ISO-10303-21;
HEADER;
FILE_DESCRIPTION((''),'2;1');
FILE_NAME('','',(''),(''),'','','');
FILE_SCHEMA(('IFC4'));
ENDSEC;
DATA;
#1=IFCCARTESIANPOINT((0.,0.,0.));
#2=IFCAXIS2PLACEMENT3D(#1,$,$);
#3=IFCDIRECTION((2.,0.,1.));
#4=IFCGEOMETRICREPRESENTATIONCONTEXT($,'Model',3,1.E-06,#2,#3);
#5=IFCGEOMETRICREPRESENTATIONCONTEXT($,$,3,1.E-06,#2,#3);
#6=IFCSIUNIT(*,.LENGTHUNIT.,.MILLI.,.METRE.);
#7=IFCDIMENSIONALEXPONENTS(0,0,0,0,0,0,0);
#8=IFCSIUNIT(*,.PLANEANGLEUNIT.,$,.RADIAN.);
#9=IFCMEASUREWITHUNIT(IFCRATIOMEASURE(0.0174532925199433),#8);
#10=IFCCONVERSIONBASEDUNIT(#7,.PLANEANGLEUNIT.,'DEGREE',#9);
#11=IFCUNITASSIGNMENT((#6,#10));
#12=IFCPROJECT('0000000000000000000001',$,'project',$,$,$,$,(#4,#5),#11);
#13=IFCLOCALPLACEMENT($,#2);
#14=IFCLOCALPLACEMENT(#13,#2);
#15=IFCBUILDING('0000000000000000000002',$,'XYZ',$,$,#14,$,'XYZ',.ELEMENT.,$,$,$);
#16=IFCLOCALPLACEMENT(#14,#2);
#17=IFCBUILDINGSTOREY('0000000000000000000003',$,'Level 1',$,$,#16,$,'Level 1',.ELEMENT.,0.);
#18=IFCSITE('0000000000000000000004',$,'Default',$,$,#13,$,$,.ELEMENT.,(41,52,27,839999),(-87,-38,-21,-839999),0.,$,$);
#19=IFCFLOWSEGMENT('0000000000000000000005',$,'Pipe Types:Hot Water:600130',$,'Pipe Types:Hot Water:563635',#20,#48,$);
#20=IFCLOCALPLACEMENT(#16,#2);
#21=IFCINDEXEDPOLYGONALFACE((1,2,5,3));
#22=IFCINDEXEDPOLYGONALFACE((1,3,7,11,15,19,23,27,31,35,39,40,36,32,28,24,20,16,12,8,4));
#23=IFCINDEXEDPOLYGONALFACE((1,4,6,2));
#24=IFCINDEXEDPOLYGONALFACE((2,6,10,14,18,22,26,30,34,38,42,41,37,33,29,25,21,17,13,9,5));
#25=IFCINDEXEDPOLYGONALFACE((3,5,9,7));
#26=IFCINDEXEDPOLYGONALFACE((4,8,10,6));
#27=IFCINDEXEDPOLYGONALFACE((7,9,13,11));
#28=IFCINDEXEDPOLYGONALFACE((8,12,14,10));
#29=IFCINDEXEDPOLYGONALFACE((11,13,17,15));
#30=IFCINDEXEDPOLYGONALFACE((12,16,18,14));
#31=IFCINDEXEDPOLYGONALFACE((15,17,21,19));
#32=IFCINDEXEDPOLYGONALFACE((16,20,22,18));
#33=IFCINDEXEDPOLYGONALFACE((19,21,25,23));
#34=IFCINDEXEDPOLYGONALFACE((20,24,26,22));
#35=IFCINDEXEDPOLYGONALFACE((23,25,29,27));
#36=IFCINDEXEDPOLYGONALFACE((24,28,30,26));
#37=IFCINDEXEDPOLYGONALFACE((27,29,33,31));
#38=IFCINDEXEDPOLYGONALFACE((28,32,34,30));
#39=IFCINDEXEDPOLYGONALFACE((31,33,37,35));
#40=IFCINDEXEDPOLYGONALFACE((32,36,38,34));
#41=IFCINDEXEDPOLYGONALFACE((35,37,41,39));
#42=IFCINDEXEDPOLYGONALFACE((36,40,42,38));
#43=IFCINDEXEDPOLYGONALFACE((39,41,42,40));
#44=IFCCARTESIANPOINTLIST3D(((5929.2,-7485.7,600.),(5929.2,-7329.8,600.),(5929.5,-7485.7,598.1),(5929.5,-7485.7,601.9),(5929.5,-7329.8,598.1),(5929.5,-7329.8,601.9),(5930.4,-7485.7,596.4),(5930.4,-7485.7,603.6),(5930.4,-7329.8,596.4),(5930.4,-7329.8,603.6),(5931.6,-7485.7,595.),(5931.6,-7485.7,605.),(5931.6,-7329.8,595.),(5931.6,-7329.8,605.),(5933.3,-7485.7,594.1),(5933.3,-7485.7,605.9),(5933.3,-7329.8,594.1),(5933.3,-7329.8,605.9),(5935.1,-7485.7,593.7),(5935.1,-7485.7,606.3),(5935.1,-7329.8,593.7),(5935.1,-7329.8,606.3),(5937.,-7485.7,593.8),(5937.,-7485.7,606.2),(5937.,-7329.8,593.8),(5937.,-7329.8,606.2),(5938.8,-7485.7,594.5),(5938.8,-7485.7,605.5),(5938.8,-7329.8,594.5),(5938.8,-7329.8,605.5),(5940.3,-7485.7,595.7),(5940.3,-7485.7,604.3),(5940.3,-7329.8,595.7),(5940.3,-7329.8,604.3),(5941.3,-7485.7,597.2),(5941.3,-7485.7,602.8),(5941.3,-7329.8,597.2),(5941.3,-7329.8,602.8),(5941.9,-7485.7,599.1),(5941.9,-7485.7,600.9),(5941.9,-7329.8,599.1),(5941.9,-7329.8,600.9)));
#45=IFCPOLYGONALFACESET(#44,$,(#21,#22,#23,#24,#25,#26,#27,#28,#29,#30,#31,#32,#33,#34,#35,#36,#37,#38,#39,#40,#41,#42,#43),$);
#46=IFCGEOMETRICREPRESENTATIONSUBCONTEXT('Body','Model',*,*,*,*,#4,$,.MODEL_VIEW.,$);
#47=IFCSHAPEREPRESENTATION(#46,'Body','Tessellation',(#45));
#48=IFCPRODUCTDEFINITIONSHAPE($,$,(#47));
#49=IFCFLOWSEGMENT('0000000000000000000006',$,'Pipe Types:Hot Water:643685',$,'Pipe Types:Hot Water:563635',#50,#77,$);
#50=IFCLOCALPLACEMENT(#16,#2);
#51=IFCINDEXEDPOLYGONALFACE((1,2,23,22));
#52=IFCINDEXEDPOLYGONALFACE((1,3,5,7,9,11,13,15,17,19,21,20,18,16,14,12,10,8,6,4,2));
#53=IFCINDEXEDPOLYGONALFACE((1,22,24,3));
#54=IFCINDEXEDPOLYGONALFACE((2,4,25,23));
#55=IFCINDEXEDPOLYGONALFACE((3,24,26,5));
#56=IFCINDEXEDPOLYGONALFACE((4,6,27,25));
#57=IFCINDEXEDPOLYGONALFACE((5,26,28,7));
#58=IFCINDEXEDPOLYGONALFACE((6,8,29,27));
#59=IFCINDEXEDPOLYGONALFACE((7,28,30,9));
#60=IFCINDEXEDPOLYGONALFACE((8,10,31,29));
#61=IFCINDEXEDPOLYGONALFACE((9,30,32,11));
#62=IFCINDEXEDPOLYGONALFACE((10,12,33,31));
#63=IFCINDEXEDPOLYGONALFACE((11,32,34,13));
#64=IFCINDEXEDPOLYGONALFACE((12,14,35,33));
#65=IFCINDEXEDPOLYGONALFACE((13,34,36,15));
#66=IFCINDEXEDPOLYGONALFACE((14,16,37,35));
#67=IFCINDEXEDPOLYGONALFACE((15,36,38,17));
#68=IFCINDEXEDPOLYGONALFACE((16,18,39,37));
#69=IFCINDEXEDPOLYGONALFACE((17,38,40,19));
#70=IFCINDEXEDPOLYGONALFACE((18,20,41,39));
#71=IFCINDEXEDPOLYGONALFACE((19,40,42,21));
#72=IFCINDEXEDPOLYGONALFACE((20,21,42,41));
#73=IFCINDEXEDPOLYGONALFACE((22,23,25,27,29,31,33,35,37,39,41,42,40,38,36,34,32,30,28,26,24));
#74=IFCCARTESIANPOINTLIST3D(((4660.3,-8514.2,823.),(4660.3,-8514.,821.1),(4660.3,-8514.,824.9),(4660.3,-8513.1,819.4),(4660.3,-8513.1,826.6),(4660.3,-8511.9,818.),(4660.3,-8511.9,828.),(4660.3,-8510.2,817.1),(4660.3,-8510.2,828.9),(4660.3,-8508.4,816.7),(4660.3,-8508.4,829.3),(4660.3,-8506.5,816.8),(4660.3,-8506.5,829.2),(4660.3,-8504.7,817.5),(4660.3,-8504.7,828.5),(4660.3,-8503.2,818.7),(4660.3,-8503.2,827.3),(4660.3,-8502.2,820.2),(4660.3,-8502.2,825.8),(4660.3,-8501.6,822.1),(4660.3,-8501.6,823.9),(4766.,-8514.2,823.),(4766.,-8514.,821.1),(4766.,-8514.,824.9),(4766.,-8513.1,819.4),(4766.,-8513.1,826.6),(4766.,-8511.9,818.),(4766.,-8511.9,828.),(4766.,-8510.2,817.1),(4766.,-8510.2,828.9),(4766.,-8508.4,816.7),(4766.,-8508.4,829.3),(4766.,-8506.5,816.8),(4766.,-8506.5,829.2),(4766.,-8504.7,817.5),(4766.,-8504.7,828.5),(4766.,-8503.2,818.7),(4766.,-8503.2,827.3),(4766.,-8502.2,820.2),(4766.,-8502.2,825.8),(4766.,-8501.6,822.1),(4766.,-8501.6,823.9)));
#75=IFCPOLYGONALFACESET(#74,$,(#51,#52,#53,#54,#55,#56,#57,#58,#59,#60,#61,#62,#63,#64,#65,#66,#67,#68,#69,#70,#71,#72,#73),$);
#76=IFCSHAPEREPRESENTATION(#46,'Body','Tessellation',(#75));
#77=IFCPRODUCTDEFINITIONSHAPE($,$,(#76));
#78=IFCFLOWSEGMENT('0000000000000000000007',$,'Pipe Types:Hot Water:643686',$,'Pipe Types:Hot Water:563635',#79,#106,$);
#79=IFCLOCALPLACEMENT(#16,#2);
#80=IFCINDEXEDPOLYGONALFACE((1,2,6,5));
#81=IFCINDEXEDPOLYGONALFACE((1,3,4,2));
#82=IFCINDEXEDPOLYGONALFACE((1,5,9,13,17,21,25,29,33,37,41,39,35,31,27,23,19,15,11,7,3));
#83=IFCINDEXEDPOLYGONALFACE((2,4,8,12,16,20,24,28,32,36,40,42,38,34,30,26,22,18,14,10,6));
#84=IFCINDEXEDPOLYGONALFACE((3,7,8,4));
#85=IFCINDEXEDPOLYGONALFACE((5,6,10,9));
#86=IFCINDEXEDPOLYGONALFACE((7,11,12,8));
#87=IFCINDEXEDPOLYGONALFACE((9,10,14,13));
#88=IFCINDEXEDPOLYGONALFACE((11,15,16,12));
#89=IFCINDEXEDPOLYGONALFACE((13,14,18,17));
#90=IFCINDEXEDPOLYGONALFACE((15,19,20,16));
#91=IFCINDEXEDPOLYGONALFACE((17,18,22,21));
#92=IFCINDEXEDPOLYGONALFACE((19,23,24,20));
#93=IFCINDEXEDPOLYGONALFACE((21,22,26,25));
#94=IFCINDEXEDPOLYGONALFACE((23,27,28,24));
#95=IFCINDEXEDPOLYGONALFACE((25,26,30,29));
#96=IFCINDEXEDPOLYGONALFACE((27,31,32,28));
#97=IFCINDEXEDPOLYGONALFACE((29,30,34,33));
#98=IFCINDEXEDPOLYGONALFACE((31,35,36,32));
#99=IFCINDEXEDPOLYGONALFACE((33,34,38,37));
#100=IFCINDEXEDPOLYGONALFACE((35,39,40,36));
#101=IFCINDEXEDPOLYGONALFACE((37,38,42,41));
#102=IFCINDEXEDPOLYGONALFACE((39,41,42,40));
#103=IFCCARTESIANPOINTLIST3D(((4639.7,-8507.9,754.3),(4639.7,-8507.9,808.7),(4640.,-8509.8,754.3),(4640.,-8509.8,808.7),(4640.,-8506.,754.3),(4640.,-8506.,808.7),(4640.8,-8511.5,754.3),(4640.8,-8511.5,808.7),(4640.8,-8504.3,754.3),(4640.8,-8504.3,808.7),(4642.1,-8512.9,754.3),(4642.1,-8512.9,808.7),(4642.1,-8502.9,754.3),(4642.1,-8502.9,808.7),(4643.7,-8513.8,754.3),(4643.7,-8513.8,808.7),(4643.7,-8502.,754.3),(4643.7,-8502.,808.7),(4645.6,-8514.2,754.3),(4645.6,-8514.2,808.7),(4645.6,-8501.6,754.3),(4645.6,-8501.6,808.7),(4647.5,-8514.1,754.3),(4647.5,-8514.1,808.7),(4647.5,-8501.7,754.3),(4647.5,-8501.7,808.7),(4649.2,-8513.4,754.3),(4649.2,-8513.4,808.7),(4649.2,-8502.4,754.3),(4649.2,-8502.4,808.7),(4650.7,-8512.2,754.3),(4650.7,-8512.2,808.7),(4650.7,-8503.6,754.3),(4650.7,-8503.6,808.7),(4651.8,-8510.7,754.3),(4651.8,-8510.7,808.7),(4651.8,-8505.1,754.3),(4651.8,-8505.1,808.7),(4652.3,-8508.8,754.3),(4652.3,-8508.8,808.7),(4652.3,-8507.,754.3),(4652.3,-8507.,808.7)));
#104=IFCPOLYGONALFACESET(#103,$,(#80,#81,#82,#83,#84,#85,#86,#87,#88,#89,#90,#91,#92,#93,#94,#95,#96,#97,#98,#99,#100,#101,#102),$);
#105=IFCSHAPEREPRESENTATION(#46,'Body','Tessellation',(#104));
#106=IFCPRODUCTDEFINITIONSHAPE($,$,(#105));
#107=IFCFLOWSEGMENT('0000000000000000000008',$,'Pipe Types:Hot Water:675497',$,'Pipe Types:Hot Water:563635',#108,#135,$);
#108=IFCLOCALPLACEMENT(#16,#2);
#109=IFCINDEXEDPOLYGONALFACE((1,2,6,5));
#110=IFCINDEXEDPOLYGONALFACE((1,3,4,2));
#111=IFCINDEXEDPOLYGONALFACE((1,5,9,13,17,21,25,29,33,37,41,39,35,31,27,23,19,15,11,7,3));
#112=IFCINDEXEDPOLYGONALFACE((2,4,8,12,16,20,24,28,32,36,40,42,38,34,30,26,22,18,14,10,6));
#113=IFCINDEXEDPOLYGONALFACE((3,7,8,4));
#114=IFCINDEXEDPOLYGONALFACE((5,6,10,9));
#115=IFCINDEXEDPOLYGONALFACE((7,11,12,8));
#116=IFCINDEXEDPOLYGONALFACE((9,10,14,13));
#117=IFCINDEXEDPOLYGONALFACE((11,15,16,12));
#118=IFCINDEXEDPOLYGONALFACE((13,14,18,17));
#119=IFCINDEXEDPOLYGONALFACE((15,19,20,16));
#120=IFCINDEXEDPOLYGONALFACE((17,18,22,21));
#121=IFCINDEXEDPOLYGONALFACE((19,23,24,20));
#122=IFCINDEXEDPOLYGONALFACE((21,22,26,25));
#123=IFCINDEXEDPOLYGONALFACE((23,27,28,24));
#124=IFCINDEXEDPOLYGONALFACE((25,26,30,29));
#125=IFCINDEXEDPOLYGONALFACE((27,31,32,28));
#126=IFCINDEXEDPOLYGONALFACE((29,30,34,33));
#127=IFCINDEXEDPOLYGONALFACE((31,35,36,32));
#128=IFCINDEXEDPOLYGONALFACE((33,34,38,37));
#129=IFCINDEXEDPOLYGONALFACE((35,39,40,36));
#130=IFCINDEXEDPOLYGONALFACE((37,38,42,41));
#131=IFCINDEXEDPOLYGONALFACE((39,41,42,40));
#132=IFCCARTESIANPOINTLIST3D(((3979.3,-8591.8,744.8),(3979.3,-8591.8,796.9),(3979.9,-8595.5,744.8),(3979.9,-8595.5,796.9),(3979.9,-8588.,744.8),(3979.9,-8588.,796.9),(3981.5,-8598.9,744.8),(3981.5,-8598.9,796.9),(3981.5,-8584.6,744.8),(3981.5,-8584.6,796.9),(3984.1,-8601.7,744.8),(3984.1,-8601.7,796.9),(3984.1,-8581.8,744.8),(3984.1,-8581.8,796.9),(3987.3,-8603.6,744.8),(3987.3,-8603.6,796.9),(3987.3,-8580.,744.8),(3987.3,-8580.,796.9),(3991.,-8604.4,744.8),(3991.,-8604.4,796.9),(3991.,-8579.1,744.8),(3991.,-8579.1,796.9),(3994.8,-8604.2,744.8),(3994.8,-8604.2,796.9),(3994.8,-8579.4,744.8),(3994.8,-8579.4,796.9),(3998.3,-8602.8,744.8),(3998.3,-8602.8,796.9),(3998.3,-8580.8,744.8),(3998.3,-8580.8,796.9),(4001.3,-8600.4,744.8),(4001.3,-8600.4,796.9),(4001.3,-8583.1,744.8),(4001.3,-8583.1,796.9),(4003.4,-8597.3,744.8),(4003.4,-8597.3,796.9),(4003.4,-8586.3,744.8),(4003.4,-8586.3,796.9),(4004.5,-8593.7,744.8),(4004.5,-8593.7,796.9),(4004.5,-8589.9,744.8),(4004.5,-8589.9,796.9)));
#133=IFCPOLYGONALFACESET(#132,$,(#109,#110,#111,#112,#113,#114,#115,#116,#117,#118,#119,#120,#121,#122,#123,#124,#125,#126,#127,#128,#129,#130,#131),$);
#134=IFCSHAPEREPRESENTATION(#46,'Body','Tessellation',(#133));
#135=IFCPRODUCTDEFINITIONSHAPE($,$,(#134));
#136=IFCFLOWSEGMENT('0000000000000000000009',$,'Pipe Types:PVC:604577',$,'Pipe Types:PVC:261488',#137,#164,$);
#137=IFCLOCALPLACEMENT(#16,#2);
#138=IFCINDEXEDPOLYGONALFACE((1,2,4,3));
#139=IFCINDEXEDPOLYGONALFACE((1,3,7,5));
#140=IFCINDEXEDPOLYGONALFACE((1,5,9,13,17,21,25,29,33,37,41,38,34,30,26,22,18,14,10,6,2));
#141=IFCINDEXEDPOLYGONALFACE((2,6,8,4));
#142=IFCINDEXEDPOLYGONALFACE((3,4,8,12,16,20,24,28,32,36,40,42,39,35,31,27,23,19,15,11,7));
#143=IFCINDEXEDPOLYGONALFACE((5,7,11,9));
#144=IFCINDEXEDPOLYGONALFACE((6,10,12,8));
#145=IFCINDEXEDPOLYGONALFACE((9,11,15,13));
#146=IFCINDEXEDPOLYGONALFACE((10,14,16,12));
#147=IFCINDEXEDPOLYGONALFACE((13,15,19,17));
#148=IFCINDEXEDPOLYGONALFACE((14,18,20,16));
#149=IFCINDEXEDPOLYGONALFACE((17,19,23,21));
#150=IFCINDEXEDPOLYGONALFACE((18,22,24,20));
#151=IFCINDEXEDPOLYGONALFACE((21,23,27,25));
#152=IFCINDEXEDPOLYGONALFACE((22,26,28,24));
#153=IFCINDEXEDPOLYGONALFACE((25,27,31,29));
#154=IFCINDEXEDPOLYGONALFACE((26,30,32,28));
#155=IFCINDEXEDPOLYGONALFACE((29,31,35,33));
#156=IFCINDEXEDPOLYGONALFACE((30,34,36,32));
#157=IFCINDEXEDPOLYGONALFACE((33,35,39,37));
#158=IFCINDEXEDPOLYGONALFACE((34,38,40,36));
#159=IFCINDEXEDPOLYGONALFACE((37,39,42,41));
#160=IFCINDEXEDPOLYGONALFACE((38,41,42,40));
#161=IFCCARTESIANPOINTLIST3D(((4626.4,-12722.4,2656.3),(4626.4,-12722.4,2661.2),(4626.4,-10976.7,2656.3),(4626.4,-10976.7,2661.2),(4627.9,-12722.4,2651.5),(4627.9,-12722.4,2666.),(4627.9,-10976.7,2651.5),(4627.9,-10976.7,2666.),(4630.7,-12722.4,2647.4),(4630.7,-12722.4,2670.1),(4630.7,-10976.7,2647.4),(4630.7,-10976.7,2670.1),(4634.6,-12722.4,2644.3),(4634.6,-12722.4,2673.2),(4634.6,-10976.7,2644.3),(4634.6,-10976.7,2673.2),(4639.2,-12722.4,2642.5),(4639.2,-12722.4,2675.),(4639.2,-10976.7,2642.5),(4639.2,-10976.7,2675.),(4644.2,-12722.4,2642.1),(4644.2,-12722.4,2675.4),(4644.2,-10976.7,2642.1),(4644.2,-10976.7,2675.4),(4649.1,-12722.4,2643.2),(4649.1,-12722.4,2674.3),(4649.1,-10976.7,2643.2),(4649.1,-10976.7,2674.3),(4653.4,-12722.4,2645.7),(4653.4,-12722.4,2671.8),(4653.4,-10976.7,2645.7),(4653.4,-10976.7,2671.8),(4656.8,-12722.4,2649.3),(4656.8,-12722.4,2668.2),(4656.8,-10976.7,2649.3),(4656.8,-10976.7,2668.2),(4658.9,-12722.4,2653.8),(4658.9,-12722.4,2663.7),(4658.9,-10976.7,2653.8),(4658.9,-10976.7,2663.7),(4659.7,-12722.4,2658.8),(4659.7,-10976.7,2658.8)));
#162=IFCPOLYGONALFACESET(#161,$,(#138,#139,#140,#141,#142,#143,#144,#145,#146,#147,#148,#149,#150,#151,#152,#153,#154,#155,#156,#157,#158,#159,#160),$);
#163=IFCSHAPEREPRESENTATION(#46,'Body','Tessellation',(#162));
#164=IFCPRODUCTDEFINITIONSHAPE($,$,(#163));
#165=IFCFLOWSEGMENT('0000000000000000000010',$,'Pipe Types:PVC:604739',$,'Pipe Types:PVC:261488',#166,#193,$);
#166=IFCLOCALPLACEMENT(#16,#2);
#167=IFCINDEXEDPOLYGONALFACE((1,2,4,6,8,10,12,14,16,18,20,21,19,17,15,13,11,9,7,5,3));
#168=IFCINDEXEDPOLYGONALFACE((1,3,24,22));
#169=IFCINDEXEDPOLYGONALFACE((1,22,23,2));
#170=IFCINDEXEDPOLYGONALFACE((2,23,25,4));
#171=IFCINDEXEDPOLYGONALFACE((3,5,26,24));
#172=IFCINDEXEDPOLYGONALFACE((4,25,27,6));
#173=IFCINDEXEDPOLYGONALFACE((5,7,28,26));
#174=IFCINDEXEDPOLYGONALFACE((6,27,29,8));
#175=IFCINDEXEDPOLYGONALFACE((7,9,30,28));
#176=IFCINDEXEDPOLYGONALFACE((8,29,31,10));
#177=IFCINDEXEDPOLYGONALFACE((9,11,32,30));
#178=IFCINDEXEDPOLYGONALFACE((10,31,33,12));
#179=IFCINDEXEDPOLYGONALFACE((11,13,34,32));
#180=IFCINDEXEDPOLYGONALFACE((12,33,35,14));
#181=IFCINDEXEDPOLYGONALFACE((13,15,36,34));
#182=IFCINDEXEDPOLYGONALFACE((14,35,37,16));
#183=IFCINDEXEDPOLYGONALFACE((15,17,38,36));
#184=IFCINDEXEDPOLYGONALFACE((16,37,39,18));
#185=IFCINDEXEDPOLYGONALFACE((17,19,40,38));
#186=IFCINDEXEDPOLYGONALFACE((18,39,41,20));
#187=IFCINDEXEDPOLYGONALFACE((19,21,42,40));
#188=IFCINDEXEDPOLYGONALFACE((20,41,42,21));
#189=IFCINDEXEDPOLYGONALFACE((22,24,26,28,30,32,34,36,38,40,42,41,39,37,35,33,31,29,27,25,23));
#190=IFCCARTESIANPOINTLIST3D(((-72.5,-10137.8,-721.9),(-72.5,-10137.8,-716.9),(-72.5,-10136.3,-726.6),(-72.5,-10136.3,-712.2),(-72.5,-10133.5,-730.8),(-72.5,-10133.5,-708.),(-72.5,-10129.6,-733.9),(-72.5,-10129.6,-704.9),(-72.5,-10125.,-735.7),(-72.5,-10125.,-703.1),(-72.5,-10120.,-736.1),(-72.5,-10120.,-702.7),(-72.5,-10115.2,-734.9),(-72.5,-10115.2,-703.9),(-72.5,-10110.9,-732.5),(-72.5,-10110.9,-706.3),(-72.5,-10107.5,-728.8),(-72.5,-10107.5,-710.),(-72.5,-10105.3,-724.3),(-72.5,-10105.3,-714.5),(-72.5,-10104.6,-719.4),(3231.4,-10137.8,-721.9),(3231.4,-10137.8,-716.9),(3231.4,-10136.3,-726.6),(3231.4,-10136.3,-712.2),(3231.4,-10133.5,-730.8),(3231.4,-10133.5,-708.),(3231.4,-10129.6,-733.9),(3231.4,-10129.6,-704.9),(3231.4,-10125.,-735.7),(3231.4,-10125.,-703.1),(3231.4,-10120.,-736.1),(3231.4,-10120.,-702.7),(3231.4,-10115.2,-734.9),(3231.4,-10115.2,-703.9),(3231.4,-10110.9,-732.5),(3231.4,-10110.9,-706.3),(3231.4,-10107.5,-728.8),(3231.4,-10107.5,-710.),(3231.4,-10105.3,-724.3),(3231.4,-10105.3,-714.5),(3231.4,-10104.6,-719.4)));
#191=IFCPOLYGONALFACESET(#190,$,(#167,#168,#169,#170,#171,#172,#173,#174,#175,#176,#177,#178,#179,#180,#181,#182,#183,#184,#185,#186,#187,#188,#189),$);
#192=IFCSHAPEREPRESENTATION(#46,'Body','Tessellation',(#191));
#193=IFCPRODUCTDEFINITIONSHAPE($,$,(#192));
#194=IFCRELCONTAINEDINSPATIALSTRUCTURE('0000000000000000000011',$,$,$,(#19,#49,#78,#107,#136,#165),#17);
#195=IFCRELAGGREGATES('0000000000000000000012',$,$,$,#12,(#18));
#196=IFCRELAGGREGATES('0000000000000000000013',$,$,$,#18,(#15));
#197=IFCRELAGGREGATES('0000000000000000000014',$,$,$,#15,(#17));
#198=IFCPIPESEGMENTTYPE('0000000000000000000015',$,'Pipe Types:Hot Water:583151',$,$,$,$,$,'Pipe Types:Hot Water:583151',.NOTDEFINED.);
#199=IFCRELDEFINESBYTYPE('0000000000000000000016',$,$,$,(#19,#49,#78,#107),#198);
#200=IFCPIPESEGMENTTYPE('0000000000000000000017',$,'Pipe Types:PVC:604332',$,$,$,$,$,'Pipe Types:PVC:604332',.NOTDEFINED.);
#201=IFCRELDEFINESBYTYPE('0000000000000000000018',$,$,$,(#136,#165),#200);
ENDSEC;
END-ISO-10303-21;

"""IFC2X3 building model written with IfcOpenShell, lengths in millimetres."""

from ifc_helpers import new_model, entity, si_unit, converted_unit, direction, frame, frame_2d, origin, origin_2d_with_axis, place, context, subcontext, project, spatial, circle, extrude, type_object, element, save


model = new_model("IFC2X3")

# Units and contexts
model_context = context("Model", 3, precision=1e-06, world=origin(), true_north=direction((2.0, 0.0, 1.0)))
context_of_model = context(None, 3, precision=1e-06, world=origin(), true_north=direction((2.0, 0.0, 1.0)))
body_context = subcontext(model_context, "Body", "Model", "MODEL_VIEW")
ifc_project = project(units=[si_unit("LENGTHUNIT", "METRE", prefix="MILLI"), converted_unit("PLANEANGLEUNIT", "DEGREE", entity("IfcRatioMeasure", 0.0174532925199433), si_unit("PLANEANGLEUNIT", "RADIAN"), dimensions=[0, 0, 0, 0, 0, 0, 0])], contexts=[model_context, context_of_model])

# Site, building, storey
site_placement = place(None, origin())
site = spatial("IfcSite", under=ifc_project, at=site_placement, Name="Default", CompositionType="ELEMENT", RefLatitude=(41, 52, 27, 839999), RefLongitude=(-87, -38, -21, -839999), RefElevation=0.0)
building_placement = place(site_placement, origin())
building = spatial("IfcBuilding", under=site, at=building_placement, Name="XYZ", LongName="XYZ", CompositionType="ELEMENT")
storey_placement = place(building_placement, origin())
storey = spatial("IfcBuildingStorey", under=building, at=storey_placement, Name="Level 1", LongName="Level 1", CompositionType="ELEMENT", Elevation=0.0)

# Flow segments
pipe_segment_type_1 = type_object("IfcPipeSegmentType", Name="Pipe Types:Hot Water:583151", ElementType="Pipe Types:Hot Water:583151", PredefinedType="NOTDEFINED")
flow_segment_1_placement = place(storey_placement, origin())
element("IfcFlowSegment", 1, at=flow_segment_1_placement, inside=storey, type_object=pipe_segment_type_1, Name="Pipe Types:Hot Water:600130", ObjectType="Pipe Types:Hot Water:563635", context=body_context, shape_type="SweptSolid", body=[
    extrude(circle(Radius=6.3, at=frame_2d((0.0, 0.0), x_axis=(1.0, 0.0))), frame((5935.6, -7485.7, 600.0), z_axis=(0.0, 1.0, 0.0), x_axis=(-1.0, 0.0, 0.0)), (0.0, 0.0, 1.0), 155.8),
])
flow_segment_2_placement = place(storey_placement, origin())
element("IfcFlowSegment", 2, at=flow_segment_2_placement, inside=storey, type_object=pipe_segment_type_1, Name="Pipe Types:Hot Water:643685", ObjectType="Pipe Types:Hot Water:563635", context=body_context, shape_type="SweptSolid", body=[
    extrude(circle(Radius=6.3, at=frame_2d((0.0, 0.0), x_axis=(1.0, 0.0))), frame((4660.3, -8507.9, 823.0), z_axis=(1.0, 0.0, 0.0), x_axis=(0.0, -1.0, 0.0)), (0.0, 0.0, 1.0), 105.7),
])
flow_segment_3_placement = place(storey_placement, origin())
element("IfcFlowSegment", 3, at=flow_segment_3_placement, inside=storey, type_object=pipe_segment_type_1, Name="Pipe Types:Hot Water:643686", ObjectType="Pipe Types:Hot Water:563635", context=body_context, shape_type="SweptSolid", body=[
    extrude(circle(Radius=6.3, at=origin_2d_with_axis()), frame((4646.0, -8507.9, 754.3), z_axis=(0.0, 0.0, 1.0), x_axis=(-1.0, 0.0, 0.0)), (0.0, 0.0, 1.0), 54.4),
])
flow_segment_4_placement = place(storey_placement, origin())
element("IfcFlowSegment", 4, at=flow_segment_4_placement, inside=storey, type_object=pipe_segment_type_1, Name="Pipe Types:Hot Water:675497", ObjectType="Pipe Types:Hot Water:563635", context=body_context, shape_type="SweptSolid", body=[
    extrude(circle(Radius=12.7, at=frame_2d((0.0, 0.0), x_axis=(1.0, 0.0))), frame((3992.0, -8591.8, 744.8), z_axis=(0.0, 0.0, 1.0), x_axis=(-1.0, 0.0, 0.0)), (0.0, 0.0, 1.0), 52.1),
])
pipe_segment_type_2 = type_object("IfcPipeSegmentType", Name="Pipe Types:PVC:604332", ElementType="Pipe Types:PVC:604332", PredefinedType="NOTDEFINED")
flow_segment_5_placement = place(storey_placement, origin())
element("IfcFlowSegment", 5, at=flow_segment_5_placement, inside=storey, type_object=pipe_segment_type_2, Name="Pipe Types:PVC:604577", ObjectType="Pipe Types:PVC:261488", context=body_context, shape_type="SweptSolid", body=[
    extrude(circle(Radius=16.7, at=origin_2d_with_axis()), frame((4643.0, -12722.4, 2658.8), z_axis=(0.0, 1.0, 0.0), x_axis=(1.0, 0.0, 0.0)), (0.0, 0.0, 1.0), 1745.7),
])
flow_segment_6_placement = place(storey_placement, origin())
element("IfcFlowSegment", 6, at=flow_segment_6_placement, inside=storey, type_object=pipe_segment_type_2, Name="Pipe Types:PVC:604739", ObjectType="Pipe Types:PVC:261488", context=body_context, shape_type="SweptSolid", body=[
    extrude(circle(Radius=16.7, at=frame_2d((0.0, 0.0), x_axis=(1.0, 0.0))), frame((-72.5, -10121.3, -719.4), z_axis=(1.0, 0.0, 0.0), x_axis=(0.0, 1.0, 0.0)), (0.0, 0.0, 1.0), 3303.8),
])

save(model, "model.ifc")
